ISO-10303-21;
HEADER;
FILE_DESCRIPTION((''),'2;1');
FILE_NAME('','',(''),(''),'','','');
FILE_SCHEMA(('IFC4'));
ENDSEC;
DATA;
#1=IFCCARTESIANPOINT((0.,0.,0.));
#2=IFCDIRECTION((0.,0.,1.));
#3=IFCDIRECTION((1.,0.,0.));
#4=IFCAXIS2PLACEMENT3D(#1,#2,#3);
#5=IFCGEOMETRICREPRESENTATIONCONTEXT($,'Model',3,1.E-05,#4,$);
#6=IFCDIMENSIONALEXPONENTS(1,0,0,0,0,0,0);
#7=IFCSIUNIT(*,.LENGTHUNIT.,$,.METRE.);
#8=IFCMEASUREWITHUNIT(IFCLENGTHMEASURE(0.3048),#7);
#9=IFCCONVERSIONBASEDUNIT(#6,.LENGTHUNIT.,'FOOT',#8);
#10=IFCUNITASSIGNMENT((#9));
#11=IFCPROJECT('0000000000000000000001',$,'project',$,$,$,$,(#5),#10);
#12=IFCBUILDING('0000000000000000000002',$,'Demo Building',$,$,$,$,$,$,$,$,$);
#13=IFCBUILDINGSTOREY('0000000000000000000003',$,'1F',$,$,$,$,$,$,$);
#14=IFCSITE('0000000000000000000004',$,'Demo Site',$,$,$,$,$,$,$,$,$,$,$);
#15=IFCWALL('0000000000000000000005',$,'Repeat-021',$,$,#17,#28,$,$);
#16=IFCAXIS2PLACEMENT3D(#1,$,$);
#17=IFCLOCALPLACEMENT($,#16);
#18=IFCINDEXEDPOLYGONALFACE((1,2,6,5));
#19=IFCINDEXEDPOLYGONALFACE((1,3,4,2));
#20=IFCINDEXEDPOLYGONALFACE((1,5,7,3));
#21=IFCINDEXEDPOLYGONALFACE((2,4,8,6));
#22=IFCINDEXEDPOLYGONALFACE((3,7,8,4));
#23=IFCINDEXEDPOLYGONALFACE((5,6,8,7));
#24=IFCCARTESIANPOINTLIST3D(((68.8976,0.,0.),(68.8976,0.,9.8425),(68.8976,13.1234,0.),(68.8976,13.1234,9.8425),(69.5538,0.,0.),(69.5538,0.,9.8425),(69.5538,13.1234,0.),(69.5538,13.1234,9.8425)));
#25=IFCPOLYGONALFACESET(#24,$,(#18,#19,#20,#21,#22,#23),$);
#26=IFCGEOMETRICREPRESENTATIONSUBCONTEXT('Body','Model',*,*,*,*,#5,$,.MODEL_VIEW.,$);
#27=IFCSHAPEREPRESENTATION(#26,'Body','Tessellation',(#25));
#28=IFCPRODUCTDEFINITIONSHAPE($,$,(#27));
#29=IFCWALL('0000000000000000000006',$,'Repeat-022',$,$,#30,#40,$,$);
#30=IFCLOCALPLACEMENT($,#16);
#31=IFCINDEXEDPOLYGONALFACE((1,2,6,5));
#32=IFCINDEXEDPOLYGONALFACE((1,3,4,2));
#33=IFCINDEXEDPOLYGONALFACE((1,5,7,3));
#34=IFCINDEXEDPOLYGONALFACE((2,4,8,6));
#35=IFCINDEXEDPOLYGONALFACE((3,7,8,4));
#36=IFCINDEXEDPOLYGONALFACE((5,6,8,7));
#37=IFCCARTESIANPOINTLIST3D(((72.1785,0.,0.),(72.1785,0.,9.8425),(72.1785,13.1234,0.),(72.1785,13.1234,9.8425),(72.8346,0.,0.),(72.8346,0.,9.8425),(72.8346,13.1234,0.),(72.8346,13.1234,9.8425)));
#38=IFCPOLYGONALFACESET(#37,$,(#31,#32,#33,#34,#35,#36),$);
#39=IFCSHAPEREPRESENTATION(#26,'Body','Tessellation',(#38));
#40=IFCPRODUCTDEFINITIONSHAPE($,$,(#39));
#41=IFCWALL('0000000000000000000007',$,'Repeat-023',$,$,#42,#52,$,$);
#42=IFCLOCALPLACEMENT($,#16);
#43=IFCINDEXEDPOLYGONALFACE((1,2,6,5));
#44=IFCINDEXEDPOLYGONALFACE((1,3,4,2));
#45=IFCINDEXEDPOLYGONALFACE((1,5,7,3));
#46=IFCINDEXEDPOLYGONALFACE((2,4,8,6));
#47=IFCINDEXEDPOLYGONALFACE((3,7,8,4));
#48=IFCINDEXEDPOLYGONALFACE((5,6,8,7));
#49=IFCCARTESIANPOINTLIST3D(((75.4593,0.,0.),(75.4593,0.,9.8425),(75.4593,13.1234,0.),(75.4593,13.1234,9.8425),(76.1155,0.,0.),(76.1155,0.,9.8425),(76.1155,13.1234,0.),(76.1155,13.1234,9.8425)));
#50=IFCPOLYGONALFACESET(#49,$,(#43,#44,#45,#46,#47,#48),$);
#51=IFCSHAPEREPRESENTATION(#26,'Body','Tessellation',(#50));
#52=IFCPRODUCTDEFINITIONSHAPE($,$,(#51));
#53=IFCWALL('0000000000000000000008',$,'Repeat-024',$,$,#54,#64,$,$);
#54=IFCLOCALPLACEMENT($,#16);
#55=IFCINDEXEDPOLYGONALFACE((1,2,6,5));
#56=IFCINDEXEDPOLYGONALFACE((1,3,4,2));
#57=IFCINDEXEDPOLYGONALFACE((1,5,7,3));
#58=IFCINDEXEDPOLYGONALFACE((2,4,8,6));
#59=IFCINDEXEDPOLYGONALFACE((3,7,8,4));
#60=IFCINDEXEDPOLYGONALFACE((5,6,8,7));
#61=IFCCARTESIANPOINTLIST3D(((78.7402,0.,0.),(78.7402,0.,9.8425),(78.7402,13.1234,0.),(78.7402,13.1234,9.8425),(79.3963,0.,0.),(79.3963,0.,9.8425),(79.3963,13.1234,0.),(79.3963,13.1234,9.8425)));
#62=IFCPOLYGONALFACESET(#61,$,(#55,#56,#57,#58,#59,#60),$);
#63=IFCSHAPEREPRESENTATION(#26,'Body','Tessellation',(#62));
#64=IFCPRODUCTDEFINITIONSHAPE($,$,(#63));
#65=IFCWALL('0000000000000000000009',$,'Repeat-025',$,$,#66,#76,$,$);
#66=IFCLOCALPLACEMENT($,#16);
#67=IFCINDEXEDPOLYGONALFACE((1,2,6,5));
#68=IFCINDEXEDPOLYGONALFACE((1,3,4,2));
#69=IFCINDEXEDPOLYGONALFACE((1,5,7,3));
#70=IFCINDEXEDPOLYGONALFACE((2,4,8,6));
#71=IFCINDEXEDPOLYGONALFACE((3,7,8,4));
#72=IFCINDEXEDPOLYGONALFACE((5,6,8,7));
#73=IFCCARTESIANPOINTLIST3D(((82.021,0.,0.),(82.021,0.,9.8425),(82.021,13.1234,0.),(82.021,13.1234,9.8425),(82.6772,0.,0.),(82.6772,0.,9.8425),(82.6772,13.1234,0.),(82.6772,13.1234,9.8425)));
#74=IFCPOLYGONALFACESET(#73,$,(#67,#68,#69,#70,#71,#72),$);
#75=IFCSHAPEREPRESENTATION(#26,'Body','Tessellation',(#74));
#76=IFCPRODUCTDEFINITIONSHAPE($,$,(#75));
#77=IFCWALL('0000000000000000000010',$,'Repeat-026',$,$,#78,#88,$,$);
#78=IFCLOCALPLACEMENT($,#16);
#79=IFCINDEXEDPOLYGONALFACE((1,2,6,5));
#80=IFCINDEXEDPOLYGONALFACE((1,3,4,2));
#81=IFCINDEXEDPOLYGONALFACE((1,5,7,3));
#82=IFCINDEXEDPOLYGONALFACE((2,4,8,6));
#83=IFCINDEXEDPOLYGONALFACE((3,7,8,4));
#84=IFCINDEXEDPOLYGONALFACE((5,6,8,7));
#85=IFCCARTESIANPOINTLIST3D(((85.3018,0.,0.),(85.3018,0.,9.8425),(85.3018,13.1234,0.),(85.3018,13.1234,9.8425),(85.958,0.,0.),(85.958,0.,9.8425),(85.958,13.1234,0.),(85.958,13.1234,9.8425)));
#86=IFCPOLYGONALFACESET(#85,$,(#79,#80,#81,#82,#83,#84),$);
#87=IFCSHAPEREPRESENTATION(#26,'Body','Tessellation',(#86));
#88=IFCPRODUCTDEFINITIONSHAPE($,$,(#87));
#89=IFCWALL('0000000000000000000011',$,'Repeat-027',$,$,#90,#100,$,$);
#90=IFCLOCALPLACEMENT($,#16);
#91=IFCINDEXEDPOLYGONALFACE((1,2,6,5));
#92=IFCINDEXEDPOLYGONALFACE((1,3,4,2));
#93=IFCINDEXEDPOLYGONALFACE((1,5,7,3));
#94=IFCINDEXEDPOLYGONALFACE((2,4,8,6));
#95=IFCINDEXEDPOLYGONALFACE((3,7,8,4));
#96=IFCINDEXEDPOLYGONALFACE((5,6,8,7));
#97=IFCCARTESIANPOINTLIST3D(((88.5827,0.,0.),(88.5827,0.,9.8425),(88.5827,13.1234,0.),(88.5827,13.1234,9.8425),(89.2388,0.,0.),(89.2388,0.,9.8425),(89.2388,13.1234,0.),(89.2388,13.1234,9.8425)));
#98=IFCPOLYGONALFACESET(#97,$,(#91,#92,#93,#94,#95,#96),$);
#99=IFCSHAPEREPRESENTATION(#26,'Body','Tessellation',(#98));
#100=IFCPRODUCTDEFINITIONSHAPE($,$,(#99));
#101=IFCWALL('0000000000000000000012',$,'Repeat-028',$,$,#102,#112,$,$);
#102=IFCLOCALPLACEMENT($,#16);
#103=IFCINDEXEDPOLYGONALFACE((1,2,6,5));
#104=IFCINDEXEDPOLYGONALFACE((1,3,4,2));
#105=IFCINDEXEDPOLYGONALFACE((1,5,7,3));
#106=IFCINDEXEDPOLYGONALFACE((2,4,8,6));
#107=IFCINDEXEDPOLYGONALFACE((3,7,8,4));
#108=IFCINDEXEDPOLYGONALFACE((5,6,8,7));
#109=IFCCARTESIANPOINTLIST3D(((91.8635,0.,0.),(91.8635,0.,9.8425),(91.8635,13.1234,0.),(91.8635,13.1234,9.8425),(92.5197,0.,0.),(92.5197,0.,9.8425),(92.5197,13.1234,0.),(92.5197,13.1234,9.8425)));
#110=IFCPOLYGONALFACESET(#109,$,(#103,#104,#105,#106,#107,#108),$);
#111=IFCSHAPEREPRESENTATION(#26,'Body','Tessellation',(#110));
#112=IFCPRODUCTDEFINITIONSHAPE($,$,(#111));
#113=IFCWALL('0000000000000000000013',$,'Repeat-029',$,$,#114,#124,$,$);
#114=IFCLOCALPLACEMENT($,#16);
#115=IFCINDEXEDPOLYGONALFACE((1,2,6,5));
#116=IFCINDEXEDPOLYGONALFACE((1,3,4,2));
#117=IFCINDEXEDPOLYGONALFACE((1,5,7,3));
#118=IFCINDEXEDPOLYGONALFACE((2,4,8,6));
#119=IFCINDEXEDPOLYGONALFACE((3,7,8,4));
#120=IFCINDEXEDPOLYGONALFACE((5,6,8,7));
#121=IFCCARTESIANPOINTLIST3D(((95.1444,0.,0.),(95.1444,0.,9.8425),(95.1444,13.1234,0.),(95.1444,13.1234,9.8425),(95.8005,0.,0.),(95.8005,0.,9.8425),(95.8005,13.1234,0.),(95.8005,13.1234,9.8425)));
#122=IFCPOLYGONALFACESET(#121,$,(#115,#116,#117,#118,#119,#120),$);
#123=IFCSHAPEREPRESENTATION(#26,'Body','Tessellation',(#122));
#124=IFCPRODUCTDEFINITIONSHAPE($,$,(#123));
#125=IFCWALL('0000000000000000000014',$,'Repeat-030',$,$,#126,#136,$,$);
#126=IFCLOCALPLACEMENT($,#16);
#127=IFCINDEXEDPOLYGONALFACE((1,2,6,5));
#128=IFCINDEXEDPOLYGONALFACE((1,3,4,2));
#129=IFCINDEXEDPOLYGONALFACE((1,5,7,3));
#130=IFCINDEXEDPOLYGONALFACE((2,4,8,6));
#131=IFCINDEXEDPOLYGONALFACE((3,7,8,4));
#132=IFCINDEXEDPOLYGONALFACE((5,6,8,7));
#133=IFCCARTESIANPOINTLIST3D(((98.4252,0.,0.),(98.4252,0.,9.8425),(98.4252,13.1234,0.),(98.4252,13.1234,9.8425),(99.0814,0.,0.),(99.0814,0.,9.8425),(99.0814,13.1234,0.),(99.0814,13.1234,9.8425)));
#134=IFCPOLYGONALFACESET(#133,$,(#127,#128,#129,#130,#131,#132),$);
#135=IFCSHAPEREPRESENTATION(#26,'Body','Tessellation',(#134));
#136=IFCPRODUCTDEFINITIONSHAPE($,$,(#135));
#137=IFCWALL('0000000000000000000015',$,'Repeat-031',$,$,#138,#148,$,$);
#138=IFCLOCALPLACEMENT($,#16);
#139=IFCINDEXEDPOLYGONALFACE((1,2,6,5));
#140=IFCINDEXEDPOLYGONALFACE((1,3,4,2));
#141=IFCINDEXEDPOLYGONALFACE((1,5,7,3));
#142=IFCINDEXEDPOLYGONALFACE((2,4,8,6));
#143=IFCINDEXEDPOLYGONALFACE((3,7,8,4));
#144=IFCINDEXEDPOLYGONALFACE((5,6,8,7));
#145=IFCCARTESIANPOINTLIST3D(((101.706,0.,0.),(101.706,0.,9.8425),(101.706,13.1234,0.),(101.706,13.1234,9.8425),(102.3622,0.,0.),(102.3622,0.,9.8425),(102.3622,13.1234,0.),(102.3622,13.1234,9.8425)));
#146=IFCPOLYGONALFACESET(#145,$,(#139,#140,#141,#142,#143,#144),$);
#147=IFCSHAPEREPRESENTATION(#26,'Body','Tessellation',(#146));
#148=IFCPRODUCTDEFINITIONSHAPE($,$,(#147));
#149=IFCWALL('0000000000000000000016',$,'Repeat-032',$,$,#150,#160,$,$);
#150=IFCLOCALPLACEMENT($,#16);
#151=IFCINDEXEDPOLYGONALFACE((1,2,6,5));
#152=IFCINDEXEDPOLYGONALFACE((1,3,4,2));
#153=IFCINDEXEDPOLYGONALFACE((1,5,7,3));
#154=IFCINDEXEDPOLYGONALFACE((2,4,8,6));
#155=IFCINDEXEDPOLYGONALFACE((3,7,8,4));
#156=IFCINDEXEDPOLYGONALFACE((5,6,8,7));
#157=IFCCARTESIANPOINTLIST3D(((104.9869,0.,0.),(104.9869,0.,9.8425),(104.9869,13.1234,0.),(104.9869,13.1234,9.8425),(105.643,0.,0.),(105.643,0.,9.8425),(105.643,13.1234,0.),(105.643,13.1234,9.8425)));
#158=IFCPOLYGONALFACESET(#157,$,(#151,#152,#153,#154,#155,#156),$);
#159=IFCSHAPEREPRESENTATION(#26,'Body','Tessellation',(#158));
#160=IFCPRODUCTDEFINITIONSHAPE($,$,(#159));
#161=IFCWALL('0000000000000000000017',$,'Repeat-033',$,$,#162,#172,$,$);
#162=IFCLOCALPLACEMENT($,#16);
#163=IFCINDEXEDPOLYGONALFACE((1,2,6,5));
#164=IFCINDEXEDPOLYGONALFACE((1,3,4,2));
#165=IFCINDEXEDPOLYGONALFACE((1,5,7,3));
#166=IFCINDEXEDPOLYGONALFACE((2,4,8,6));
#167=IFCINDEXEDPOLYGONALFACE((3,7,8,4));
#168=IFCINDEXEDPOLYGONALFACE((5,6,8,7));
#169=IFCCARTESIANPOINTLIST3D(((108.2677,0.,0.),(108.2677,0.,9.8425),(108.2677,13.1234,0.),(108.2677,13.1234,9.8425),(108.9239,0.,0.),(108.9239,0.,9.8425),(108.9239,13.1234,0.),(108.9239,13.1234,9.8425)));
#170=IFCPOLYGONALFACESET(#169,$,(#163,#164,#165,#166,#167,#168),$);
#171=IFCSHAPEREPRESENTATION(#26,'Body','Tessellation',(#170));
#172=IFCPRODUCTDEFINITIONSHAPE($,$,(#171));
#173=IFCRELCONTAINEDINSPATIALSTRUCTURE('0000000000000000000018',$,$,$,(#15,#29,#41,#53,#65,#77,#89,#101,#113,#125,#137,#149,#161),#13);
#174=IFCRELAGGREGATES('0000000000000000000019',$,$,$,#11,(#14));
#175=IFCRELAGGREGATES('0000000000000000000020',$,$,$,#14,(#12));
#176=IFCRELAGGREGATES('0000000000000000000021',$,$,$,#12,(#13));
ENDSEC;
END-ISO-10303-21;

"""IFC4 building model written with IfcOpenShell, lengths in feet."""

from ifc_helpers import new_model, entity, si_unit, converted_unit, frame, origin_with_axes, place, context, subcontext, project, spatial, element, save


model = new_model("IFC4")

# Units and contexts
model_context = context("Model", 3, precision=1e-05, world=origin_with_axes())
body_context = subcontext(model_context, "Body", "Model", "MODEL_VIEW")
ifc_project = project(units=[converted_unit("LENGTHUNIT", "FOOT", entity("IfcLengthMeasure", 0.3048), si_unit("LENGTHUNIT", "METRE"), dimensions=[1, 0, 0, 0, 0, 0, 0])], contexts=[model_context])

# Site, building, storey
site = spatial("IfcSite", under=ifc_project, Name="Demo Site")
building = spatial("IfcBuilding", under=site, Name="Demo Building")
storey = spatial("IfcBuildingStorey", under=building, Name="1F")

# Walls
for number, where, z_axis, x_axis, name in (
    (1, (68.8976, 0.0, 0.0), (0.0, 0.0, 1.0), (1.0, 0.0, 0.0), "Repeat-021"),
    (2, (72.1785, 0.0, 0.0), (0.0, 0.0, 1.0), (1.0, 0.0, 0.0), "Repeat-022"),
    (3, (75.4593, 0.0, 0.0), (0.0, 0.0, 1.0), (1.0, 0.0, 0.0), "Repeat-023"),
    (4, (78.7402, 0.0, 0.0), (0.0, 0.0, 1.0), (1.0, 0.0, 0.0), "Repeat-024"),
    (5, (82.021, 0.0, 0.0), (0.0, 0.0, 1.0), (1.0, 0.0, 0.0), "Repeat-025"),
    (6, (85.3018, 0.0, 0.0), (0.0, 0.0, 1.0), (1.0, 0.0, 0.0), "Repeat-026"),
    (7, (88.5827, 0.0, 0.0), (0.0, 0.0, 1.0), (1.0, 0.0, 0.0), "Repeat-027"),
    (8, (91.8635, 0.0, 0.0), (0.0, 0.0, 1.0), (1.0, 0.0, 0.0), "Repeat-028"),
    (9, (95.1444, 0.0, 0.0), (0.0, 0.0, 1.0), (1.0, 0.0, 0.0), "Repeat-029"),
    (10, (98.4252, 0.0, 0.0), (0.0, 0.0, 1.0), (1.0, 0.0, 0.0), "Repeat-030"),
    (11, (101.706, 0.0, 0.0), (0.0, 0.0, 1.0), (1.0, 0.0, 0.0), "Repeat-031"),
    (12, (104.9869, 0.0, 0.0), (0.0, 0.0, 1.0), (1.0, 0.0, 0.0), "Repeat-032"),
    (13, (108.2677, 0.0, 0.0), (0.0, 0.0, 1.0), (1.0, 0.0, 0.0), "Repeat-033"),
):
    element("IfcWall", number, at=place(None, frame(where, z_axis=z_axis, x_axis=x_axis)), inside=storey, Name=name, context=body_context, shape_type="CSG", body=[
        entity("IfcBlock", entity("IfcAxis2Placement3D", entity("IfcCartesianPoint", [0.0, 0.0, 0.0]), entity("IfcDirection", [0.0, 0.0, 1.0]), entity("IfcDirection", [1.0, 0.0, 0.0])), 0.6562, 13.1234, 9.8425),
    ])

save(model, "model.ifc")
